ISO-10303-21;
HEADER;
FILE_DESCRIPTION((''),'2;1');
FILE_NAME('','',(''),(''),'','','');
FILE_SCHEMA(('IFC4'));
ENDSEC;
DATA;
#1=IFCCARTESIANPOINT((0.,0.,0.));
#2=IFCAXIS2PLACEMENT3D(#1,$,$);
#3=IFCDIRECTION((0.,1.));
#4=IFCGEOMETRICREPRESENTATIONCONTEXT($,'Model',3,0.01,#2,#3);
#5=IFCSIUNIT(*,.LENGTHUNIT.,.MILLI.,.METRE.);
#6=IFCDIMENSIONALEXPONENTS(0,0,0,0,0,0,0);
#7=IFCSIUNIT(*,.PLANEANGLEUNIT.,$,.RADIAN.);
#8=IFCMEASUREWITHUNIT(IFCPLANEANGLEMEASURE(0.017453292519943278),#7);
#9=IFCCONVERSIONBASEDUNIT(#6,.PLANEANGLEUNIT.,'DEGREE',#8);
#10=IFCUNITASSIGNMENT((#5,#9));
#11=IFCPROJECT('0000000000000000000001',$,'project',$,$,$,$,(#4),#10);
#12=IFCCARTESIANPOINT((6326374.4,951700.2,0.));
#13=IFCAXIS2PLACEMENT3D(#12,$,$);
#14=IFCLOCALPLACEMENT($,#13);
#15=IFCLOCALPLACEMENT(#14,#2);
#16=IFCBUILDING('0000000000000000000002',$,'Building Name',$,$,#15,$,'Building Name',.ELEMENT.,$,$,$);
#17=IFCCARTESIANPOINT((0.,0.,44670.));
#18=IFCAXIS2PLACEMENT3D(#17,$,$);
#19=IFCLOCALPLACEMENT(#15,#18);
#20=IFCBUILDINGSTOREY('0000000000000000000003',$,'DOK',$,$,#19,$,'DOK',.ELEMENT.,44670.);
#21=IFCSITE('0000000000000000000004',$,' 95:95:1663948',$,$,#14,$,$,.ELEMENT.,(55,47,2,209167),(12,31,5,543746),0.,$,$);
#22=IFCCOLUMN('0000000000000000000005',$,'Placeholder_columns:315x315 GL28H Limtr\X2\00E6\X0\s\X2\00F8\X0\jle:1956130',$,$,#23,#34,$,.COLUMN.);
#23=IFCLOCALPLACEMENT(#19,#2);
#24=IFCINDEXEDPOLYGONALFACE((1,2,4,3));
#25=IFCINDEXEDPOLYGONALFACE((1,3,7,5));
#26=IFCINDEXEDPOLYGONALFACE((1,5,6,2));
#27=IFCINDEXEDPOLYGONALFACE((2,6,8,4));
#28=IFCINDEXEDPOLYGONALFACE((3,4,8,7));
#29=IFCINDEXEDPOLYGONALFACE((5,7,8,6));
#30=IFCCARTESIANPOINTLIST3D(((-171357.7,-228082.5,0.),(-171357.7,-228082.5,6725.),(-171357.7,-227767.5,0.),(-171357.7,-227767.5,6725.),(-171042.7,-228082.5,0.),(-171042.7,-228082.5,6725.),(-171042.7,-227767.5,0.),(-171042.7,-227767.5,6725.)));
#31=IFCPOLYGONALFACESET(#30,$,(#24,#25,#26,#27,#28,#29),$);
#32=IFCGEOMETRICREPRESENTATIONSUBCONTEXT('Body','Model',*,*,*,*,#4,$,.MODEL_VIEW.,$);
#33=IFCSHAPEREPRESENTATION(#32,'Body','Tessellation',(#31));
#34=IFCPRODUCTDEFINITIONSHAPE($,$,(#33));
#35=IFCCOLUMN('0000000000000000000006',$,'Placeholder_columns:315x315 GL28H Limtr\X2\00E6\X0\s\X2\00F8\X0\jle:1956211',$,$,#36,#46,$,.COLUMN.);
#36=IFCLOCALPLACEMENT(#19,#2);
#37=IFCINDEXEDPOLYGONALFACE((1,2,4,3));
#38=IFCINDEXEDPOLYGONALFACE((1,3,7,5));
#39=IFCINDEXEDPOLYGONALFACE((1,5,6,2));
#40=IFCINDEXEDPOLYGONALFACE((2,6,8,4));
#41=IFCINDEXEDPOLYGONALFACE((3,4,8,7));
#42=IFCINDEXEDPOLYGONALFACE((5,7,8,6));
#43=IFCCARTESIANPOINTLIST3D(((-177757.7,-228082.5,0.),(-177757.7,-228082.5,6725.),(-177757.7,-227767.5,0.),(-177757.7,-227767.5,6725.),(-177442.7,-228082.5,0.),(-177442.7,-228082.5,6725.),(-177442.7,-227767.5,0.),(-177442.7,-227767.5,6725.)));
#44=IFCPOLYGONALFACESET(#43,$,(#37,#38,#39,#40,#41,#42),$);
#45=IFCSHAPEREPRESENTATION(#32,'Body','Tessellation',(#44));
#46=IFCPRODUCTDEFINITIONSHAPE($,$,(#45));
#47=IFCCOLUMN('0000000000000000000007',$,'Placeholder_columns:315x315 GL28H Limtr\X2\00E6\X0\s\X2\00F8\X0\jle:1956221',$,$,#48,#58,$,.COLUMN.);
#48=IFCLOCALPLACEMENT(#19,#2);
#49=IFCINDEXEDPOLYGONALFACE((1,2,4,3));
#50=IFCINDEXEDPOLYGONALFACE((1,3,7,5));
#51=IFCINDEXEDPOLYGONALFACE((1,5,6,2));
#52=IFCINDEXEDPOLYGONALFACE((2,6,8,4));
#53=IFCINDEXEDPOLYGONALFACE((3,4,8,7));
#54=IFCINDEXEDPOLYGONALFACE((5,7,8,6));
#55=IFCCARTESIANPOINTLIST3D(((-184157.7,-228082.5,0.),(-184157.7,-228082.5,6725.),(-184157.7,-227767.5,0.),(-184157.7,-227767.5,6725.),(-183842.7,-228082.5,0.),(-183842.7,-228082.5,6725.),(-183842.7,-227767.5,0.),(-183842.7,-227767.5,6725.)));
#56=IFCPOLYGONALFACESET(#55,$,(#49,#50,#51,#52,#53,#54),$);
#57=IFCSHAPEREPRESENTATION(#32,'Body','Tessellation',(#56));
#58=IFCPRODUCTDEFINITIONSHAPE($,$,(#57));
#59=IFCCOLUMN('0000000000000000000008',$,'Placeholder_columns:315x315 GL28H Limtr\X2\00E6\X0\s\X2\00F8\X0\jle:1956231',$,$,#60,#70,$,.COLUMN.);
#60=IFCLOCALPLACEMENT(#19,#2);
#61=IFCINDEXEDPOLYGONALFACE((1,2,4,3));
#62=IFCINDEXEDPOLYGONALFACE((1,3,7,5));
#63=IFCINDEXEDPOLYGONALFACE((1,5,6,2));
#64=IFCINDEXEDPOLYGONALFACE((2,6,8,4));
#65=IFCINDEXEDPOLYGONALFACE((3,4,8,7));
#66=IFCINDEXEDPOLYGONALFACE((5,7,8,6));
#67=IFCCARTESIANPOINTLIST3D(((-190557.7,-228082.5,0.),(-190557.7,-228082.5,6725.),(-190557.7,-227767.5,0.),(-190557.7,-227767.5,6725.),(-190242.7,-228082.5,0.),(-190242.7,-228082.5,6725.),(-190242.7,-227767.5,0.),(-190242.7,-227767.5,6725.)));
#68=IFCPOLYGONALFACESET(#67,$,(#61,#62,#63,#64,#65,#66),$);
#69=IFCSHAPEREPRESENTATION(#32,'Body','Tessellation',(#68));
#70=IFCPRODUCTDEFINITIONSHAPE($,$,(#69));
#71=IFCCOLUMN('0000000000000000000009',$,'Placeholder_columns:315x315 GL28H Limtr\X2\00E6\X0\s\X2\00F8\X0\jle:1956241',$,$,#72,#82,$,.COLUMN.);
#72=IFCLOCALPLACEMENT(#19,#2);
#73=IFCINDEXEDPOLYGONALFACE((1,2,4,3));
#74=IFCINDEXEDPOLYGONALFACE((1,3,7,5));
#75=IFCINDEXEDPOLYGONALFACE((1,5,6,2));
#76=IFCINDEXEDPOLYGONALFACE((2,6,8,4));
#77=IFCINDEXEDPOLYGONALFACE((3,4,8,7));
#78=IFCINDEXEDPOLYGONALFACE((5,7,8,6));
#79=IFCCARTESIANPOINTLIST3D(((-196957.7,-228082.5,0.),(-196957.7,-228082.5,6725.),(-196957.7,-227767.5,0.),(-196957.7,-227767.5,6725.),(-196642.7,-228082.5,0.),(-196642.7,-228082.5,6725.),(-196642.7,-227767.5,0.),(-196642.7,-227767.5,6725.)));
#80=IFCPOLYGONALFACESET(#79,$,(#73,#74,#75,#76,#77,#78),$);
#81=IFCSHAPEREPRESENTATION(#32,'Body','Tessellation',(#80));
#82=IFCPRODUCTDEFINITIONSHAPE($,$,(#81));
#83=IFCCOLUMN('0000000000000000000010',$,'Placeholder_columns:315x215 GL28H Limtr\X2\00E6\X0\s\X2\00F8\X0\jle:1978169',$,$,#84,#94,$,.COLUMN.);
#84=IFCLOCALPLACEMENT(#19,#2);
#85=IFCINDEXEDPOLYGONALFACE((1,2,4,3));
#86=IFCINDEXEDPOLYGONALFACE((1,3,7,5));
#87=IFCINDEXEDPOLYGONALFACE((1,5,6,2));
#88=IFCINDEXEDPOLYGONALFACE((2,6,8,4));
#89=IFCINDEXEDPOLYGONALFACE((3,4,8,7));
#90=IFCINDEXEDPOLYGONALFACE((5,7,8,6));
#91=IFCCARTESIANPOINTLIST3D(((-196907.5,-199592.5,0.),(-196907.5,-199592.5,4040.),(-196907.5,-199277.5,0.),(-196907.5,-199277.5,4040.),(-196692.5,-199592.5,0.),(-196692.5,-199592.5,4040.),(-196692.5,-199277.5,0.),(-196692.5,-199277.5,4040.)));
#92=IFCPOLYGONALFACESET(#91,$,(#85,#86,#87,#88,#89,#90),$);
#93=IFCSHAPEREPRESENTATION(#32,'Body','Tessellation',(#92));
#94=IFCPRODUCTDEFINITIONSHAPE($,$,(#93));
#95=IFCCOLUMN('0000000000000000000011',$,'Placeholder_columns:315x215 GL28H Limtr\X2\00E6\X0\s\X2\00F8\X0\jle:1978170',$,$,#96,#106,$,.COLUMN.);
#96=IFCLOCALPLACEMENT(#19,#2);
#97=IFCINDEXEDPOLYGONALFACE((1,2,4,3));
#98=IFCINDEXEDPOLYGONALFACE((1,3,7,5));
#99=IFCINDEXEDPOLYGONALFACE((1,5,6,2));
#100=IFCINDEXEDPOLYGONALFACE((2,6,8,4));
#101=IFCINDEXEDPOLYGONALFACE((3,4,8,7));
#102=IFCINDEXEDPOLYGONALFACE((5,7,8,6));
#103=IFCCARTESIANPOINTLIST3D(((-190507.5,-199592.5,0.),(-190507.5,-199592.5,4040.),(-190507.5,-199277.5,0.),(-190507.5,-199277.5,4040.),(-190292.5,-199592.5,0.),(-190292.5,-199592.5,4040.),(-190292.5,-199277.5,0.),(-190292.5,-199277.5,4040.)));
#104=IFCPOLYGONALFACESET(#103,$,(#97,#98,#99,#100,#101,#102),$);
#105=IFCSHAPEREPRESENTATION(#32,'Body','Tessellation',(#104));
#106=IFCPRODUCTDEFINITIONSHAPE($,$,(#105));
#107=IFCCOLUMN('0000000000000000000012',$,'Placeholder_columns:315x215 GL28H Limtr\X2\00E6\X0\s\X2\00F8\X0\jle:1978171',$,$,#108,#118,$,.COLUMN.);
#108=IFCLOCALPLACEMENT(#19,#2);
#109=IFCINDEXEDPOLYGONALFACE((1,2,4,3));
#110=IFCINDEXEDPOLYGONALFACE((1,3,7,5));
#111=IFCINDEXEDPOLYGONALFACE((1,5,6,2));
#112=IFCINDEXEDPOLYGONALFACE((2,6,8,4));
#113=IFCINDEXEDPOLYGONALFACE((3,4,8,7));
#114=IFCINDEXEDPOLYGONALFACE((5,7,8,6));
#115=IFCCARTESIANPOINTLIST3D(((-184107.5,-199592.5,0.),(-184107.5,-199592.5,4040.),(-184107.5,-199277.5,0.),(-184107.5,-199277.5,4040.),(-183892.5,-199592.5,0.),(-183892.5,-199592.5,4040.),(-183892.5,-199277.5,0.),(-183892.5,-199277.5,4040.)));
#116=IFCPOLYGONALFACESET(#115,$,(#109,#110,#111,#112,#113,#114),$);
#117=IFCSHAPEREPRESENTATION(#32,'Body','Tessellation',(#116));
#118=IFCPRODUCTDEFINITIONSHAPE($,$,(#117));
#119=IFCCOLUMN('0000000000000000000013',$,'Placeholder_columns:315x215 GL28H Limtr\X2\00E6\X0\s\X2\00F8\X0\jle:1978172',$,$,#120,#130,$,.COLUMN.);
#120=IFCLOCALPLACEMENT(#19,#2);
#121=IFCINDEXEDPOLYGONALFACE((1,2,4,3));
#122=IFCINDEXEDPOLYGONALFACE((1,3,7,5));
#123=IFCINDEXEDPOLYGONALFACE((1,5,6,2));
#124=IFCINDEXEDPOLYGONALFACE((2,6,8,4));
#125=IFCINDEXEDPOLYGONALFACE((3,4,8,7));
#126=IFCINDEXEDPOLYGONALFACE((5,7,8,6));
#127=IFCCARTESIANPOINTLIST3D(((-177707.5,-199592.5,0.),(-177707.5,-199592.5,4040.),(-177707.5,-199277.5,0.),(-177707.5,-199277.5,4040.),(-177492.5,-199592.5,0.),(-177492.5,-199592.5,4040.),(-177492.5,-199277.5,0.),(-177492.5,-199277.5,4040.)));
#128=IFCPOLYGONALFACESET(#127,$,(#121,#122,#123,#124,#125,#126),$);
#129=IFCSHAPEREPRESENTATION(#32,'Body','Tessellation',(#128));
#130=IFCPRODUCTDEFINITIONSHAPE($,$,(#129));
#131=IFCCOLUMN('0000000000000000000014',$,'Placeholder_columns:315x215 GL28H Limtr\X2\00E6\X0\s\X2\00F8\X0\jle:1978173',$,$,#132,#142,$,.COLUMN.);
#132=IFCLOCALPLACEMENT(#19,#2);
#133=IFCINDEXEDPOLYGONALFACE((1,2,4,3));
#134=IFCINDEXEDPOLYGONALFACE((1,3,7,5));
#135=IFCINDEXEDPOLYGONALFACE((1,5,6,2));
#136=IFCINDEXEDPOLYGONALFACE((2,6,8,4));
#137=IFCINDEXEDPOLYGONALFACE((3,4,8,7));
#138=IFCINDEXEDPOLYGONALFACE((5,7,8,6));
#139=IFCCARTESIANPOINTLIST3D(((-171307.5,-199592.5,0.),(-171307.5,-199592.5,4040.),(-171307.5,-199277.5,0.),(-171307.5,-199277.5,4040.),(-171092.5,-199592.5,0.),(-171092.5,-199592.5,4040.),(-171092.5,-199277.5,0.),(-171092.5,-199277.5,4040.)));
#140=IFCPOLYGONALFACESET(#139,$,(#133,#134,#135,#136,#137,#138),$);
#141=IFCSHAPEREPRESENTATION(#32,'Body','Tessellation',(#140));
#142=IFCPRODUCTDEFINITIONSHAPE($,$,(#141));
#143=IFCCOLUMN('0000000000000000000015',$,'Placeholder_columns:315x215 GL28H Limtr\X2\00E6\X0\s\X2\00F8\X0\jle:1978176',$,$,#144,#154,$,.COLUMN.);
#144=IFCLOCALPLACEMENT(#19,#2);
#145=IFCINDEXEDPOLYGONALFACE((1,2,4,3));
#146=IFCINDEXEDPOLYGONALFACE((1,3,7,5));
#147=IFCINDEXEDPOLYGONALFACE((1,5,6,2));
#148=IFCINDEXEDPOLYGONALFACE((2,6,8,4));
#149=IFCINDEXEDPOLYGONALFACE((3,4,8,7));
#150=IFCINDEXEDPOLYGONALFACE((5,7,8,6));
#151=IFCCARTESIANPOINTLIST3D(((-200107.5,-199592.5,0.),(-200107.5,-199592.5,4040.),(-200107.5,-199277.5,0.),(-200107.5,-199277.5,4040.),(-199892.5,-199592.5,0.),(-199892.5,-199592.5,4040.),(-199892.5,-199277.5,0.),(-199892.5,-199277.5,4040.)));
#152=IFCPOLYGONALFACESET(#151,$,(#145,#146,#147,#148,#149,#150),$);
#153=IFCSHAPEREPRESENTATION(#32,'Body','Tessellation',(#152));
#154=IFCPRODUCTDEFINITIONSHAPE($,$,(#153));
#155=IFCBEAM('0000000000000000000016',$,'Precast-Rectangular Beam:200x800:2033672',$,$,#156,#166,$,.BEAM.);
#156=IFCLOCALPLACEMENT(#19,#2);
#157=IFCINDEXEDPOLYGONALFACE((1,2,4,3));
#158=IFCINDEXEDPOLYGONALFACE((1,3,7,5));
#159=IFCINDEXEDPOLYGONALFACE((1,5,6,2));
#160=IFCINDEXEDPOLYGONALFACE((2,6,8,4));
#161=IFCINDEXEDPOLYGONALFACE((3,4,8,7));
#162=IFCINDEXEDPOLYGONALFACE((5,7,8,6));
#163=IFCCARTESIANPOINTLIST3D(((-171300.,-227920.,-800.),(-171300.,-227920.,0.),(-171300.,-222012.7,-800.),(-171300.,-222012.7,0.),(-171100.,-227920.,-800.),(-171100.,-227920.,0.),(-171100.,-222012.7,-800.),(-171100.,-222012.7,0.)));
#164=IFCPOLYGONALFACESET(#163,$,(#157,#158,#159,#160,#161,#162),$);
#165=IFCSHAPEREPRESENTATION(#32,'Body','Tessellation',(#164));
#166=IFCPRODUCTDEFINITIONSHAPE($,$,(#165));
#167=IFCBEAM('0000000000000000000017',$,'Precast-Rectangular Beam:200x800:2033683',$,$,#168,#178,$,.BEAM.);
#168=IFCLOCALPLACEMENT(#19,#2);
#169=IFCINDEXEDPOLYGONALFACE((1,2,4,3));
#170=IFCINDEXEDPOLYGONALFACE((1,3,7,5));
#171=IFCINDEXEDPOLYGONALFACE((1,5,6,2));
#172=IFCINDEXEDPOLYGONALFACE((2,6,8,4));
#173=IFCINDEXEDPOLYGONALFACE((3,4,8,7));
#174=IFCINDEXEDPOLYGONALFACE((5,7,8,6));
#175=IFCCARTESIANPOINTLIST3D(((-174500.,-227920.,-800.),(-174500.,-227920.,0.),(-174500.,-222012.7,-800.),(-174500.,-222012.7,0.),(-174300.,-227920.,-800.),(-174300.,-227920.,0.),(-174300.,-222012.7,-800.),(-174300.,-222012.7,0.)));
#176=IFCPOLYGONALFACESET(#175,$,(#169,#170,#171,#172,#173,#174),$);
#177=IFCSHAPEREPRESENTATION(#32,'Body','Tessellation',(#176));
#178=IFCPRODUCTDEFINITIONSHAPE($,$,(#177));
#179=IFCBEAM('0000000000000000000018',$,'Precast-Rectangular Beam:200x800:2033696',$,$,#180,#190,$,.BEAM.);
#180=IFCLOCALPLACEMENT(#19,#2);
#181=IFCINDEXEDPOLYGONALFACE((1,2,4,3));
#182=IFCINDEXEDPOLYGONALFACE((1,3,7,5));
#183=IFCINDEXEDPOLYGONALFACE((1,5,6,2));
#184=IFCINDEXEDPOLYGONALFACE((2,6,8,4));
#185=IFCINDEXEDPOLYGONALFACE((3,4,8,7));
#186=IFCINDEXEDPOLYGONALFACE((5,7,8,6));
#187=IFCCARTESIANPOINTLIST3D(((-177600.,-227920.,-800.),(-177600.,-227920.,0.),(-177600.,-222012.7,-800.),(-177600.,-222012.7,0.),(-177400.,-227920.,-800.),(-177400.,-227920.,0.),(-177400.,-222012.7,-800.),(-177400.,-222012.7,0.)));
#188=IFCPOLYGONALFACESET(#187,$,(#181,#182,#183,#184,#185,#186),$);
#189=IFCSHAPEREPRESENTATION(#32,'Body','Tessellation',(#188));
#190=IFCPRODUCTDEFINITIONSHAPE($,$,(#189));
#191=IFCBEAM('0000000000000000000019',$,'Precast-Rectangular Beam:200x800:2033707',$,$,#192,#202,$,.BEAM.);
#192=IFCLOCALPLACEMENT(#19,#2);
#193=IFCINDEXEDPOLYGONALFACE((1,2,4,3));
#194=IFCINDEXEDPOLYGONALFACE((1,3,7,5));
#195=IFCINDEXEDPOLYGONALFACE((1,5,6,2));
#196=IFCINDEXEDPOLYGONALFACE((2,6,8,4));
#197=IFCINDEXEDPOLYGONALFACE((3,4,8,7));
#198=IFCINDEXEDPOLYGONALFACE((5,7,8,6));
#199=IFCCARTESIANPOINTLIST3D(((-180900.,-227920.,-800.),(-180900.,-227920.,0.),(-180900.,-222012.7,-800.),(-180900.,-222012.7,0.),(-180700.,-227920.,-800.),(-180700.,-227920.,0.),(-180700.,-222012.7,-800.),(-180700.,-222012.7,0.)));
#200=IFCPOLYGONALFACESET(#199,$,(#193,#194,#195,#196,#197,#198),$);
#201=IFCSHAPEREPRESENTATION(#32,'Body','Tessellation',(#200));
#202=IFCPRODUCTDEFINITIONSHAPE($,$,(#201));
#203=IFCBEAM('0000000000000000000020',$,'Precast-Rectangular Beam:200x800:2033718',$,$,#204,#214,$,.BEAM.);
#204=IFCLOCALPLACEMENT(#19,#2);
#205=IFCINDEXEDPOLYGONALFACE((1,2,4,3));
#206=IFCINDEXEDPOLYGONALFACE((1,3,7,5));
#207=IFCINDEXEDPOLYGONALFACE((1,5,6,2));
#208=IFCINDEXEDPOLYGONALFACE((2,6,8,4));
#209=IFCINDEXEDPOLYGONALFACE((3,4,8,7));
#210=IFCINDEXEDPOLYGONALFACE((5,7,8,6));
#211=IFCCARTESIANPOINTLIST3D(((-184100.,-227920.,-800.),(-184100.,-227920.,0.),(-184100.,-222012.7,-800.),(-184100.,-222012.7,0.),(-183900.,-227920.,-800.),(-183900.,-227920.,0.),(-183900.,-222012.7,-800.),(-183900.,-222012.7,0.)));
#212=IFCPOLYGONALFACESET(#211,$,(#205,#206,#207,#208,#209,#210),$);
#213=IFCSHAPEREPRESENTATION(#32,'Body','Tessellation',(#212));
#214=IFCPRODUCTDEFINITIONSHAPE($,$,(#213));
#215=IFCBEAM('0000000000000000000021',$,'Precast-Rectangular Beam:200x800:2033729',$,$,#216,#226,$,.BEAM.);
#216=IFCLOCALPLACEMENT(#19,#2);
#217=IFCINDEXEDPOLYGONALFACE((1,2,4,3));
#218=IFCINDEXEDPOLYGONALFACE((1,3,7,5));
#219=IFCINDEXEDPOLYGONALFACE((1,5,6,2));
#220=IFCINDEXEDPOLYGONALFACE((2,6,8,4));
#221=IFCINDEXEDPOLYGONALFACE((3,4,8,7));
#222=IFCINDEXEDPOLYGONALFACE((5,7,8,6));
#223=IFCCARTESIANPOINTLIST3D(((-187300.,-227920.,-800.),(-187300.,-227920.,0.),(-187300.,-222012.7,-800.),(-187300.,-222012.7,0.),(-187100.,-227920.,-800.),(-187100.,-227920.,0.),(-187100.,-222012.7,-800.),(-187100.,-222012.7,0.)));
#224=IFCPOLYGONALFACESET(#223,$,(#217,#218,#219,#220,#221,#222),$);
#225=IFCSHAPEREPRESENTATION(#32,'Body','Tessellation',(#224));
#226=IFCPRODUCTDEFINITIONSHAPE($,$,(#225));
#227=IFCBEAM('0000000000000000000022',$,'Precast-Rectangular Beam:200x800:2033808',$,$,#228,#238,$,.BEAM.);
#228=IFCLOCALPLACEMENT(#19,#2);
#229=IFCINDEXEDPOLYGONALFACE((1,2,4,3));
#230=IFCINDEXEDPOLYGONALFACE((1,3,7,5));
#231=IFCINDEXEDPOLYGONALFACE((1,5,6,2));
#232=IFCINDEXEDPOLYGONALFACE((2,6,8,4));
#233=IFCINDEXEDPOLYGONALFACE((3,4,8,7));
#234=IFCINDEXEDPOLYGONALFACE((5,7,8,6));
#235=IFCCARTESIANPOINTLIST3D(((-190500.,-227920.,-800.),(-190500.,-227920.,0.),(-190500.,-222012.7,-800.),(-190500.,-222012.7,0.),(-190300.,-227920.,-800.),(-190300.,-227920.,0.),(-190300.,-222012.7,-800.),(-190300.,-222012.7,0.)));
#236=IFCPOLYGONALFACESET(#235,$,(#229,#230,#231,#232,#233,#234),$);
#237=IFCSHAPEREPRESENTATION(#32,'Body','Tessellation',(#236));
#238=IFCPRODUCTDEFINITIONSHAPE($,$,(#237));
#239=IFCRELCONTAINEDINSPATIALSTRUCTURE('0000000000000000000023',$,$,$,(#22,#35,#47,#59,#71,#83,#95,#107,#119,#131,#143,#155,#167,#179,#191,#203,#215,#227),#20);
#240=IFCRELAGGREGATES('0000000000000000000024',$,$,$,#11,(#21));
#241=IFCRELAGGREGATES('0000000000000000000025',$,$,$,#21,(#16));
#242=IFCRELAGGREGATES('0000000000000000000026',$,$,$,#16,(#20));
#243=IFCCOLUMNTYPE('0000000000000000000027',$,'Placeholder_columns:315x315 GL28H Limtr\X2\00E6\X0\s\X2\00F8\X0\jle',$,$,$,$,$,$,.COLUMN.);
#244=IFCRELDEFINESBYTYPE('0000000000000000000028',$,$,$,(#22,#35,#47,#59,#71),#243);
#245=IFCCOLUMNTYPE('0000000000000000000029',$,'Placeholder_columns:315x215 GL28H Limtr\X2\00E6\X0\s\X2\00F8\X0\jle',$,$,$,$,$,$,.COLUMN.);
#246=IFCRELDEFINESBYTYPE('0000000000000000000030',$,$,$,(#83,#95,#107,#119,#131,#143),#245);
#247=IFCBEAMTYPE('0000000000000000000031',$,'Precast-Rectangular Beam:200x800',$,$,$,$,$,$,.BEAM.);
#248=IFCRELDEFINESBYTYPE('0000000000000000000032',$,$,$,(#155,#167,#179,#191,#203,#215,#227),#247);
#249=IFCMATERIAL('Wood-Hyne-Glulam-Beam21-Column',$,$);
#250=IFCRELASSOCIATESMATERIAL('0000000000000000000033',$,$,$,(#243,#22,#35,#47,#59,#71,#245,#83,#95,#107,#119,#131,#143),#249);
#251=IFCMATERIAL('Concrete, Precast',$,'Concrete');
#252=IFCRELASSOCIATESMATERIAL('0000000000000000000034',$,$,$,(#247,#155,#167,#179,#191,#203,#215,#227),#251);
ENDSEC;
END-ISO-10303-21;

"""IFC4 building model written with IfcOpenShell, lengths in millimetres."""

from ifc_helpers import new_model, entity, si_unit, converted_unit, direction, frame, origin, place, context, subcontext, project, spatial, indexed_curve, outline, extrude, source, transform, mapped, material, type_object, type_shapes, element, save


model = new_model("IFC4")

# Units and contexts
model_context = context("Model", 3, precision=0.01, world=origin(), true_north=direction((0.0, 1.0)))
body_context = subcontext(model_context, "Body", "Model", "MODEL_VIEW")
ifc_project = project(units=[si_unit("LENGTHUNIT", "METRE", prefix="MILLI"), converted_unit("PLANEANGLEUNIT", "DEGREE", entity("IfcPlaneAngleMeasure", 0.017453292519943278), si_unit("PLANEANGLEUNIT", "RADIAN"), dimensions=[0, 0, 0, 0, 0, 0, 0])], contexts=[model_context])

# Site, building, storey
site_placement = place(None, frame((6326374.4, 951700.2, 0.0)))
site = spatial("IfcSite", under=ifc_project, at=site_placement, Name=" 95:95:1663948", CompositionType="ELEMENT", RefLatitude=(55, 47, 2, 209167), RefLongitude=(12, 31, 5, 543746), RefElevation=0.0)
building_placement = place(site_placement, origin())
building = spatial("IfcBuilding", under=site, at=building_placement, Name="Building Name", LongName="Building Name", CompositionType="ELEMENT")
storey_placement = place(building_placement, frame((0.0, 0.0, 44670.0)))
storey = spatial("IfcBuildingStorey", under=building, at=storey_placement, Name="DOK", LongName="DOK", CompositionType="ELEMENT", Elevation=44670.0)

# Columns
ifc_material_1 = material(Name="Wood-Hyne-Glulam-Beam21-Column")
column_type_1 = type_object("IfcColumnType", Name="Placeholder_columns:315x315 GL28H Limtræsøjle", PredefinedType="COLUMN", material=ifc_material_1)
shared_shape_1 = source(origin(), body_context, "Body", "SweptSolid", [
    extrude(outline(indexed_curve([(-157.5, -157.5), (157.5, -157.5), (157.5, 157.5), (-157.5, 157.5), (-157.5, -157.5)], self_intersect=False)), frame((0.0, 0.0, 44670.0), z_axis=(0.0, 0.0, 1.0), x_axis=(-1.0, 0.0, 0.0)), (0.0, 0.0, 1.0), 6725.0),
])
type_shapes(column_type_1, [shared_shape_1])
for number, where, name in (
    (1, (-171200.2, -227925.0, -44670.0), "Placeholder_columns:315x315 GL28H Limtræsøjle:1956130"),
    (2, (-177600.2, -227925.0, -44670.0), "Placeholder_columns:315x315 GL28H Limtræsøjle:1956211"),
    (3, (-184000.2, -227925.0, -44670.0), "Placeholder_columns:315x315 GL28H Limtræsøjle:1956221"),
    (4, (-190400.2, -227925.0, -44670.0), "Placeholder_columns:315x315 GL28H Limtræsøjle:1956231"),
    (5, (-196800.2, -227925.0, -44670.0), "Placeholder_columns:315x315 GL28H Limtræsøjle:1956241"),
):
    element("IfcColumn", number, at=place(storey_placement, frame(where)), inside=storey, type_object=column_type_1, material=ifc_material_1, Name=name, PredefinedType="COLUMN", context=body_context, shape_type="MappedRepresentation", body=[
        mapped(shared_shape_1, transform((0.0, 0.0, 0.0), scale=1.0)),
    ])
column_type_2 = type_object("IfcColumnType", Name="Placeholder_columns:315x215 GL28H Limtræsøjle", PredefinedType="COLUMN", material=ifc_material_1)
shared_shape_2 = source(origin(), body_context, "Body", "SweptSolid", [
    extrude(outline(indexed_curve([(-107.5, -157.5), (107.5, -157.5), (107.5, 157.5), (-107.5, 157.5), (-107.5, -157.5)], self_intersect=False)), frame((0.0, 0.0, 44670.0), z_axis=(0.0, 0.0, 1.0), x_axis=(-1.0, 0.0, 0.0)), (0.0, 0.0, 1.0), 4040.0),
])
type_shapes(column_type_2, [shared_shape_2])
for number, where, name in (
    (6, (-196800.0, -199435.0, -44670.0), "Placeholder_columns:315x215 GL28H Limtræsøjle:1978169"),
    (7, (-190400.0, -199435.0, -44670.0), "Placeholder_columns:315x215 GL28H Limtræsøjle:1978170"),
    (8, (-184000.0, -199435.0, -44670.0), "Placeholder_columns:315x215 GL28H Limtræsøjle:1978171"),
    (9, (-177600.0, -199435.0, -44670.0), "Placeholder_columns:315x215 GL28H Limtræsøjle:1978172"),
    (10, (-171200.0, -199435.0, -44670.0), "Placeholder_columns:315x215 GL28H Limtræsøjle:1978173"),
    (11, (-200000.0, -199435.0, -44670.0), "Placeholder_columns:315x215 GL28H Limtræsøjle:1978176"),
):
    element("IfcColumn", number, at=place(storey_placement, frame(where)), inside=storey, type_object=column_type_2, material=ifc_material_1, Name=name, PredefinedType="COLUMN", context=body_context, shape_type="MappedRepresentation", body=[
        mapped(shared_shape_2, transform((0.0, 0.0, 0.0), scale=1.0)),
    ])

# Beams
ifc_material_2 = material(Name="Concrete, Precast", Category="Concrete")
beam_type_1 = type_object("IfcBeamType", Name="Precast-Rectangular Beam:200x800", PredefinedType="BEAM", material=ifc_material_2)
shared_shape_3 = source(origin(), body_context, "Body", "SweptSolid", [
    extrude(outline(indexed_curve([(-2953.7, -100.0), (2953.7, -100.0), (2953.7, 100.0), (-2953.7, 100.0), (-2953.7, -100.0)], self_intersect=False)), frame((-66.4, 0.0, -400.0), z_axis=(0.0, 0.0, 1.0), x_axis=(-1.0, 0.0, 0.0)), (0.0, 0.0, 1.0), 800.0),
])
type_shapes(beam_type_1, [shared_shape_3])
for number, where, z_axis, x_axis, name in (
    (12, (-171200.0, -224900.0, -400.0), (0.0, 0.0, 1.0), (0.0, 1.0, 0.0), "Precast-Rectangular Beam:200x800:2033672"),
    (13, (-174400.0, -224900.0, -400.0), (0.0, 0.0, 1.0), (0.0, 1.0, 0.0), "Precast-Rectangular Beam:200x800:2033683"),
    (14, (-177500.0, -224900.0, -400.0), (0.0, 0.0, 1.0), (0.0, 1.0, 0.0), "Precast-Rectangular Beam:200x800:2033696"),
    (15, (-180800.0, -224900.0, -400.0), (0.0, 0.0, 1.0), (0.0, 1.0, 0.0), "Precast-Rectangular Beam:200x800:2033707"),
    (16, (-184000.0, -224900.0, -400.0), (0.0, 0.0, 1.0), (0.0, 1.0, 0.0), "Precast-Rectangular Beam:200x800:2033718"),
    (17, (-187200.0, -224900.0, -400.0), (0.0, 0.0, 1.0), (0.0, 1.0, 0.0), "Precast-Rectangular Beam:200x800:2033729"),
    (18, (-190400.0, -224900.0, -400.0), (0.0, 0.0, 1.0), (0.0, 1.0, 0.0), "Precast-Rectangular Beam:200x800:2033808"),
):
    element("IfcBeam", number, at=place(storey_placement, frame(where, z_axis=z_axis, x_axis=x_axis)), inside=storey, type_object=beam_type_1, material=ifc_material_2, Name=name, PredefinedType="BEAM", context=body_context, shape_type="MappedRepresentation", body=[
        mapped(shared_shape_3, transform((0.0, 0.0, 0.0), scale=1.0)),
    ])

save(model, "model.ifc")
